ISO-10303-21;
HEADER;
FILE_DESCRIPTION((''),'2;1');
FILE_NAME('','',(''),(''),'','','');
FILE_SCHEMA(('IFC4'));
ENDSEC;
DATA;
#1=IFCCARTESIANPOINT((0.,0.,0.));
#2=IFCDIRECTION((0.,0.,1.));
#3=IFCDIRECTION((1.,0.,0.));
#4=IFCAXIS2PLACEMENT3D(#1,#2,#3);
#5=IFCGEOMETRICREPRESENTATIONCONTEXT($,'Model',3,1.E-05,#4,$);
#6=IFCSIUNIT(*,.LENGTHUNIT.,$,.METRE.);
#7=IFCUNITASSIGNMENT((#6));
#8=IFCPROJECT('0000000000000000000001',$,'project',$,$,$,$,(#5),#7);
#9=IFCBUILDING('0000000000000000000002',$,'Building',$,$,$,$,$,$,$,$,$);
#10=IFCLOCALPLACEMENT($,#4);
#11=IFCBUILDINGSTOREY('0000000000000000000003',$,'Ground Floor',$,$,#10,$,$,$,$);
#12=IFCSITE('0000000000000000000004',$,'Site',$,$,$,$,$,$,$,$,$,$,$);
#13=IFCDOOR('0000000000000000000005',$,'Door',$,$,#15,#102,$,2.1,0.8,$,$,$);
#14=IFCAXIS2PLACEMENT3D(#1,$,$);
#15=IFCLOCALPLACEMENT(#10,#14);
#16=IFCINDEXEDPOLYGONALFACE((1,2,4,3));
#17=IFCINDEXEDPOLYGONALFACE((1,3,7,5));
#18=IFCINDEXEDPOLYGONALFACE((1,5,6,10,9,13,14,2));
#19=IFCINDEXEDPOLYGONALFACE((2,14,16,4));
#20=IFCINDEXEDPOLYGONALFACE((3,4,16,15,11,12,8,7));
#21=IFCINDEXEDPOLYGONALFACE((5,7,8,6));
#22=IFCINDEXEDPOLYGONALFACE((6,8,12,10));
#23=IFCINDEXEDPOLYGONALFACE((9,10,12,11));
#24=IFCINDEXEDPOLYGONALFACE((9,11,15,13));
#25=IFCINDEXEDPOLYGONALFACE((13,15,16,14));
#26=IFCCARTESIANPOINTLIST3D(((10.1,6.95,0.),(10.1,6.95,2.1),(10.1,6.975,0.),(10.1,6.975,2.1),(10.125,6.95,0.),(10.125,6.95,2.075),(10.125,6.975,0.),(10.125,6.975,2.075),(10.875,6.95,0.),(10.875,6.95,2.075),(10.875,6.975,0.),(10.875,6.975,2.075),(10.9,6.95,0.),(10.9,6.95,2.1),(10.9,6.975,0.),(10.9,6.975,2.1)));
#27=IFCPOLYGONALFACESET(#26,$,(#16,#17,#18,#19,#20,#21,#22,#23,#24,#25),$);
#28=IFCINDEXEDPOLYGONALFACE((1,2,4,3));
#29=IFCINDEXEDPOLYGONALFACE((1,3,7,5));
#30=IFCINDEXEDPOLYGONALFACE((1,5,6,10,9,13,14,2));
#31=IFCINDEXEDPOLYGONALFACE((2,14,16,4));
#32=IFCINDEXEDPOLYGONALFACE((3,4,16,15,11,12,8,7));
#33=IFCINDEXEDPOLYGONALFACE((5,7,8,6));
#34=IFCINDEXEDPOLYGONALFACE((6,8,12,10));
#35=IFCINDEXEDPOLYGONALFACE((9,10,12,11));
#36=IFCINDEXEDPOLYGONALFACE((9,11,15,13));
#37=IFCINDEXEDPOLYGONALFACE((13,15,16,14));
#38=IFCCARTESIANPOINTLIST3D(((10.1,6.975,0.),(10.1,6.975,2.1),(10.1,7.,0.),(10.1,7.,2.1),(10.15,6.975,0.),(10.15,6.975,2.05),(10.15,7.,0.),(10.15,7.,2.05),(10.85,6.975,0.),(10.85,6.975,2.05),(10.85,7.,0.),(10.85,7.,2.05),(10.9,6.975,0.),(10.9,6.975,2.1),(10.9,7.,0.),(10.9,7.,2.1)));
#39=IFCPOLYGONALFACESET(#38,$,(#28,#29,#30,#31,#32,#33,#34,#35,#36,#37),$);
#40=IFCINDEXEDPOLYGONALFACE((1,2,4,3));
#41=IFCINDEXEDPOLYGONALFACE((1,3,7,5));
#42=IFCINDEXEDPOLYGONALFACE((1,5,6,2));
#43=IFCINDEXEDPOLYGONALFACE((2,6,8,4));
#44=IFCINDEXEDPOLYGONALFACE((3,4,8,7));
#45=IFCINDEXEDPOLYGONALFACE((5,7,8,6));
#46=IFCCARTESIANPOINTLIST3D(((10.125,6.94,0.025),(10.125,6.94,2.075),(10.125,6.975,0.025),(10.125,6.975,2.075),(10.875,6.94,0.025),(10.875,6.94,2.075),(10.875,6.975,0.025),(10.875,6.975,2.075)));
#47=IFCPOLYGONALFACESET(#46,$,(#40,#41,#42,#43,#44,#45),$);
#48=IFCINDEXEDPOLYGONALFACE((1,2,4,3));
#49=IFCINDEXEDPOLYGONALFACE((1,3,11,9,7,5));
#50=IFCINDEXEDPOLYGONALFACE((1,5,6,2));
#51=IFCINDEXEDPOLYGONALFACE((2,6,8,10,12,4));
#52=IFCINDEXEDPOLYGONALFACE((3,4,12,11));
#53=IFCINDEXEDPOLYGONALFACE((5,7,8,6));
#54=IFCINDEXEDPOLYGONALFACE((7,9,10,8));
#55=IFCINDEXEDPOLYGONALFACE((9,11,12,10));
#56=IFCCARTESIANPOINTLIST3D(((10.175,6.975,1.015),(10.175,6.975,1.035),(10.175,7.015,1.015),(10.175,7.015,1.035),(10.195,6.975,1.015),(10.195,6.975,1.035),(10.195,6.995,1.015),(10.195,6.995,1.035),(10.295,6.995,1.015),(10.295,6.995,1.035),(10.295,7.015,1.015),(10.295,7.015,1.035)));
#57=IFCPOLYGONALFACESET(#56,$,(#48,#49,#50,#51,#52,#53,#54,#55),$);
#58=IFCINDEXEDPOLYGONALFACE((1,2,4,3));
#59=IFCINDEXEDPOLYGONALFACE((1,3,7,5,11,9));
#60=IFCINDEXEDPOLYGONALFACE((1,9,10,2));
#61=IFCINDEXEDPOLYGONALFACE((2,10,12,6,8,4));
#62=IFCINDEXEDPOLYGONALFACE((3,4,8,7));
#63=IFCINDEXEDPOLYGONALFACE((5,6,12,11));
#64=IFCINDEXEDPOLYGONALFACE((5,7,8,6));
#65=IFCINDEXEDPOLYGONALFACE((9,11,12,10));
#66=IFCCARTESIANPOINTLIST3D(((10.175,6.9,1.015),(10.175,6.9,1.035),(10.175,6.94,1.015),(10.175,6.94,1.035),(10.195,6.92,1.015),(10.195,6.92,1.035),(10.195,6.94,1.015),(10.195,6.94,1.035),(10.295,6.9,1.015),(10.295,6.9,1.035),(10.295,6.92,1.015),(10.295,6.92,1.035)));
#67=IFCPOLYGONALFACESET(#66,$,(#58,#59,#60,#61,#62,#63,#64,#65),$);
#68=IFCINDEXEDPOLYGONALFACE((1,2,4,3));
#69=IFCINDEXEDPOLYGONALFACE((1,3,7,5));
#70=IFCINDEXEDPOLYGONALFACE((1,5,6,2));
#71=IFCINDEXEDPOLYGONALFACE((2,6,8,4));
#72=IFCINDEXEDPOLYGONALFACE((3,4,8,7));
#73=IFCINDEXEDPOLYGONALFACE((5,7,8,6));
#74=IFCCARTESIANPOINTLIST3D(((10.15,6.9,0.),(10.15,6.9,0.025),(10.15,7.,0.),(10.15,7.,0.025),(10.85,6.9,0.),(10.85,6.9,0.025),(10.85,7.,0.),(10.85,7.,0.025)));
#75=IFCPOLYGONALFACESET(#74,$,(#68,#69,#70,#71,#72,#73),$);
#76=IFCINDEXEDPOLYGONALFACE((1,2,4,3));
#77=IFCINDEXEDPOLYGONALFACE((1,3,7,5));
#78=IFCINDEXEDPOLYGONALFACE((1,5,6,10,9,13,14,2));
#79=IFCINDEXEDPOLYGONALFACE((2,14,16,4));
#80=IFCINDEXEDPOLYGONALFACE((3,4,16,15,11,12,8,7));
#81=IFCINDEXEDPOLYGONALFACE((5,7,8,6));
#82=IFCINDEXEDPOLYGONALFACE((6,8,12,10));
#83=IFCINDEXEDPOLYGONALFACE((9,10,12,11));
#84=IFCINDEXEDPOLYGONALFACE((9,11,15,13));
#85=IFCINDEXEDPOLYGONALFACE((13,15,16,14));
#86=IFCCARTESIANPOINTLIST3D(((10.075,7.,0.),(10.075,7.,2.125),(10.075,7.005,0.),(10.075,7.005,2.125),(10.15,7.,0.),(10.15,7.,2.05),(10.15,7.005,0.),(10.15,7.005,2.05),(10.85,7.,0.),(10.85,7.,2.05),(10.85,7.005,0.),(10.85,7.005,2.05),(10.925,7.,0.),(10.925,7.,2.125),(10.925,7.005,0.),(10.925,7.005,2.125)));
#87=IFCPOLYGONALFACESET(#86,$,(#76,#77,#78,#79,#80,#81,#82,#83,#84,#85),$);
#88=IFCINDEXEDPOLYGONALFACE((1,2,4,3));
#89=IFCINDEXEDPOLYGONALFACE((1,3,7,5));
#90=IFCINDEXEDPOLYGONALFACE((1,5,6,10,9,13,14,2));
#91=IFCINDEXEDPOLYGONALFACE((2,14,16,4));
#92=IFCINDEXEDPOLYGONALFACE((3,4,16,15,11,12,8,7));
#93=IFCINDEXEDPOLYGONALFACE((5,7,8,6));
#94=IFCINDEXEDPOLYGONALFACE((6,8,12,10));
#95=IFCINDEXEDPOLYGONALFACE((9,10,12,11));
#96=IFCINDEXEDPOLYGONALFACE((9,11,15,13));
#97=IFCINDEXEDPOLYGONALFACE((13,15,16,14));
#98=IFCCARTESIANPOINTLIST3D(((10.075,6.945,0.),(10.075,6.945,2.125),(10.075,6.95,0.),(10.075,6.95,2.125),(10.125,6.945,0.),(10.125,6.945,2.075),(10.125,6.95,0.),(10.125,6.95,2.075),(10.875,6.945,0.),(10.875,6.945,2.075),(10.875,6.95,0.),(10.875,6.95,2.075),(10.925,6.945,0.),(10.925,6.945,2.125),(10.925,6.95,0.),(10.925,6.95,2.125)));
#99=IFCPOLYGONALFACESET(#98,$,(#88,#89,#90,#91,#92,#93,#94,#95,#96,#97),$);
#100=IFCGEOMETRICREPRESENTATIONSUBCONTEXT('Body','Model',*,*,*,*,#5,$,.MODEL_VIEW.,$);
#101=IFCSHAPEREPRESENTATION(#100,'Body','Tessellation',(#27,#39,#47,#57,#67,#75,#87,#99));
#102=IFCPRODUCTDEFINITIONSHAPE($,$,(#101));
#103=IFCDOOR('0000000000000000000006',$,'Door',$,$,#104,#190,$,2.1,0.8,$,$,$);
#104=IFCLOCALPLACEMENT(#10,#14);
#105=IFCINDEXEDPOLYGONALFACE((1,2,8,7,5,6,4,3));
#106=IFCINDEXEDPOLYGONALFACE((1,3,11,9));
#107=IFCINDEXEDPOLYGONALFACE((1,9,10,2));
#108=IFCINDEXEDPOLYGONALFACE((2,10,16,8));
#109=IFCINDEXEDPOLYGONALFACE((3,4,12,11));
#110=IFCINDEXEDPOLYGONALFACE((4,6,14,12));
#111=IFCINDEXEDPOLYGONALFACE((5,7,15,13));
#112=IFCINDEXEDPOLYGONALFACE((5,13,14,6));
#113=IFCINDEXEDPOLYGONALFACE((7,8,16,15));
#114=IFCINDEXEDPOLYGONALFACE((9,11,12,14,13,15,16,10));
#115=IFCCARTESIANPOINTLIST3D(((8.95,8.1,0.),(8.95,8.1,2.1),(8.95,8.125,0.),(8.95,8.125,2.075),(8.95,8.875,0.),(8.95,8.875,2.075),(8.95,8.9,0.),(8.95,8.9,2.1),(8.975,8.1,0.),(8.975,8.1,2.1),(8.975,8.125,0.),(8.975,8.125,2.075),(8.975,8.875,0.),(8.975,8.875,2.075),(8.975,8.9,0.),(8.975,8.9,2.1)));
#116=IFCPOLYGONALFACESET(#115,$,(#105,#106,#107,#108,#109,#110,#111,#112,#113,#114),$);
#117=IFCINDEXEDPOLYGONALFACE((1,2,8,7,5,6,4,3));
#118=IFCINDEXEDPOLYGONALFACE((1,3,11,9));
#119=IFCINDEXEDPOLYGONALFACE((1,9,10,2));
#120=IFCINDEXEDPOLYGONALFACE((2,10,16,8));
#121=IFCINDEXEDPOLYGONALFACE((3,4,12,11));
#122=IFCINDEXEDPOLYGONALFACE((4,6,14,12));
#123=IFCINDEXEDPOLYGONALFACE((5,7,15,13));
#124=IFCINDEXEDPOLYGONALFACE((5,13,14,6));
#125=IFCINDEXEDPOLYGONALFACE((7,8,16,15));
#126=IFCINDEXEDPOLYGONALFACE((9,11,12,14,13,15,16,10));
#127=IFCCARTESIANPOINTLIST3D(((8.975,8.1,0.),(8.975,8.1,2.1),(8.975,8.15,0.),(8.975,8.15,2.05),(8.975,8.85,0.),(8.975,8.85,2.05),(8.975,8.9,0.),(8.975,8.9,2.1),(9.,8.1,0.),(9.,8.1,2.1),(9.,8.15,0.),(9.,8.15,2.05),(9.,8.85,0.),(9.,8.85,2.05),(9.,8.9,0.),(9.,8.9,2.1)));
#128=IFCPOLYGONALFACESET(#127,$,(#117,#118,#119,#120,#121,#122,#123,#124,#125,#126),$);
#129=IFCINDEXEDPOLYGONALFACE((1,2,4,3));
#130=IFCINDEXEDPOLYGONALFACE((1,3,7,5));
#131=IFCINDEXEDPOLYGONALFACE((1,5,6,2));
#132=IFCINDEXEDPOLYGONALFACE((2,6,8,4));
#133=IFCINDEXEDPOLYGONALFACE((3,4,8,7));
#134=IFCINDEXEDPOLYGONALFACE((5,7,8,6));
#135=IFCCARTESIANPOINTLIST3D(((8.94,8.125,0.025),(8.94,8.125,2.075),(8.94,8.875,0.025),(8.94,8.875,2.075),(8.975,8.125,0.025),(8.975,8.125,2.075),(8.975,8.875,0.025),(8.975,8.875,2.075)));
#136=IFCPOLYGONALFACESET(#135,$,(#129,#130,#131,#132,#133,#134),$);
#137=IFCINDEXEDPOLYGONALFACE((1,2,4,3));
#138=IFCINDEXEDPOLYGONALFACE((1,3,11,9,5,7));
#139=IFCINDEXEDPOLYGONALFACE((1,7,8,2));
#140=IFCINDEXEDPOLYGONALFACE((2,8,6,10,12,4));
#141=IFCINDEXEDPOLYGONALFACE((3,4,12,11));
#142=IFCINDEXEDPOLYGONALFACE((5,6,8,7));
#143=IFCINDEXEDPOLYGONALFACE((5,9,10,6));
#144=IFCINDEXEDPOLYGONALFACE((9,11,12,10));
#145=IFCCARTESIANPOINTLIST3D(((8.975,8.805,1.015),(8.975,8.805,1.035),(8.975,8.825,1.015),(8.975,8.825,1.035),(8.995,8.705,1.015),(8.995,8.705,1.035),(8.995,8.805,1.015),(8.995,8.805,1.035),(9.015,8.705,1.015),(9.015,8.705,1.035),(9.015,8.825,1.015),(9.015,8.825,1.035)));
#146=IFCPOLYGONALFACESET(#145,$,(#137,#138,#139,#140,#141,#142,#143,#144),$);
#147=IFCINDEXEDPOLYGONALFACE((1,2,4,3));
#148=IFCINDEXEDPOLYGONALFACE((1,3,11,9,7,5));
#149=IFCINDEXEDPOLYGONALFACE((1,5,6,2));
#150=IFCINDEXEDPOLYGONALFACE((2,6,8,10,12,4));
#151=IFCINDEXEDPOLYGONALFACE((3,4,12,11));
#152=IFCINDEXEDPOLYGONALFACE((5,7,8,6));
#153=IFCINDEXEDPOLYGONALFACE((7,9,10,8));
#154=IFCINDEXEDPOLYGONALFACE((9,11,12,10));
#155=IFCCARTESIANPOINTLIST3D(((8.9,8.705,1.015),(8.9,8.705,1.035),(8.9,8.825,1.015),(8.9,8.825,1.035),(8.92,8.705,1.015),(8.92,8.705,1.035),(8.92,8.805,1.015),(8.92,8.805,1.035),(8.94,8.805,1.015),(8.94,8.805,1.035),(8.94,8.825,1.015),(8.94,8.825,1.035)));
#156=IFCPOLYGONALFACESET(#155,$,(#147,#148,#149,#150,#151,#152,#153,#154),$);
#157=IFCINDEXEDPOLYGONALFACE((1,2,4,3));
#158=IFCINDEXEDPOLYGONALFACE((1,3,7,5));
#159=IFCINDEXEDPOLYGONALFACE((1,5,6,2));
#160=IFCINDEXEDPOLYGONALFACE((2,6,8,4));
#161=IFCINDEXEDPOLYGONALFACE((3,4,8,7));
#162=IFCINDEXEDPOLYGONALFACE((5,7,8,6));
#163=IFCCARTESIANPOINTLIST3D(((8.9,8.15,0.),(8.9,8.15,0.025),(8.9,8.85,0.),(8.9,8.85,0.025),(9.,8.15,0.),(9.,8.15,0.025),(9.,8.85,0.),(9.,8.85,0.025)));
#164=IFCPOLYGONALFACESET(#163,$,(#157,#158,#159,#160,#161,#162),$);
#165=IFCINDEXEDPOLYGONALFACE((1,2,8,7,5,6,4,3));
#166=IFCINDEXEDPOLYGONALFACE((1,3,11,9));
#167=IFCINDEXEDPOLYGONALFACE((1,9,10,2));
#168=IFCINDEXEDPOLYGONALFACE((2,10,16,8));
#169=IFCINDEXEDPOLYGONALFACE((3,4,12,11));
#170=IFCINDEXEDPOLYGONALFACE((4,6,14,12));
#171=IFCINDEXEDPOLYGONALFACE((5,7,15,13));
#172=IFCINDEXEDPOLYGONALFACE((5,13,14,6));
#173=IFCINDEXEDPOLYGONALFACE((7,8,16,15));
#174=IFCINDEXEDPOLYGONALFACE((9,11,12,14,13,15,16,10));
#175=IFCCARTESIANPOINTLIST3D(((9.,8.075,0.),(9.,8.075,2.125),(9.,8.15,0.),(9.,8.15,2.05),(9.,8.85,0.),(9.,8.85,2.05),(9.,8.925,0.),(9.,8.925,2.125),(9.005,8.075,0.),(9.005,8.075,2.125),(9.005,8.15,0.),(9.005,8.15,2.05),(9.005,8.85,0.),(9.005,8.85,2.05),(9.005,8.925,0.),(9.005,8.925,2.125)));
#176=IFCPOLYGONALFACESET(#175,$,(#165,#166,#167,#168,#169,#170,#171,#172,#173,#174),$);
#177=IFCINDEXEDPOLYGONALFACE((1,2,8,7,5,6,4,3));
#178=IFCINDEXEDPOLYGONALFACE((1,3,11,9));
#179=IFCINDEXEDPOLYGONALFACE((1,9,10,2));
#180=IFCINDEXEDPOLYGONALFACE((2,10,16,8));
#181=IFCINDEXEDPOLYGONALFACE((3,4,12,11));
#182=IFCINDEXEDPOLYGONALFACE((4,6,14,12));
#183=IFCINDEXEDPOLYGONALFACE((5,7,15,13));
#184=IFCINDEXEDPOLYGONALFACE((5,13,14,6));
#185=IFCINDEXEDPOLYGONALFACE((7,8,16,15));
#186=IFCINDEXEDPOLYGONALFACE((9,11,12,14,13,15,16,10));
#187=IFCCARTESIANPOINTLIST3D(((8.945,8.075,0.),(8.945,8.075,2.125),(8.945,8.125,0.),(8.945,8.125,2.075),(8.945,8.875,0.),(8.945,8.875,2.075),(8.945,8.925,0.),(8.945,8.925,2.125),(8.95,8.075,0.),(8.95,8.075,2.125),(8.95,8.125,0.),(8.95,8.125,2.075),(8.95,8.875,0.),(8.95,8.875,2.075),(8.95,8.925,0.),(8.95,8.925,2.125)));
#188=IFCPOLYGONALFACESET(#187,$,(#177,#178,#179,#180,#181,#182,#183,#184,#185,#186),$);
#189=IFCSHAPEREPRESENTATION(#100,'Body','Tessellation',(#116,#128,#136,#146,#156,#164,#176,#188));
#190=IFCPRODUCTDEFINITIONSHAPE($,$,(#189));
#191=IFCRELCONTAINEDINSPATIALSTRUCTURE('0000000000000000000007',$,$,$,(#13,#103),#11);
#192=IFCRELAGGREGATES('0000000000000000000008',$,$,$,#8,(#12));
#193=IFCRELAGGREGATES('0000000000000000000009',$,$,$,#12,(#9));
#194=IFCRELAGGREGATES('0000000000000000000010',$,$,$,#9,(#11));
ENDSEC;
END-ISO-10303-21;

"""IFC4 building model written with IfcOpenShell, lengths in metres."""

from ifc_helpers import new_model, si_unit, frame, origin_with_axes, place, context, subcontext, project, spatial, line, indexed_curve, outline, extrude, element, save


model = new_model("IFC4")

# Units and contexts
model_context = context("Model", 3, precision=1e-05, world=origin_with_axes())
body_context = subcontext(model_context, "Body", "Model", "MODEL_VIEW")
ifc_project = project(units=[si_unit("LENGTHUNIT", "METRE")], contexts=[model_context])

# Site, building, storey
site = spatial("IfcSite", under=ifc_project, Name="Site")
building = spatial("IfcBuilding", under=site, Name="Building")
storey_placement = place(None, origin_with_axes())
storey = spatial("IfcBuildingStorey", under=building, at=storey_placement, Name="Ground Floor")

# Doors
door_1_placement = place(storey_placement, frame((10.9, 7.0, 0.0), z_axis=(0.0, 0.0, 1.0), x_axis=(-1.0, 0.0, 0.0)))
element("IfcDoor", 1, at=door_1_placement, inside=storey, Name="Door", OverallHeight=2.1, OverallWidth=0.8, context=body_context, shape_type="SweptSolid", body=[
    extrude(outline(indexed_curve([(0.0, 0.0), (0.0, 2.1), (0.8, 2.1), (0.8, 0.0), (0.775, 0.0), (0.775, 2.075), (0.025, 2.075), (0.025, 0.0)], segments=[line(1, 2, 3, 4, 5, 6, 7, 8, 1)])), frame((0.0, 0.025, 0.0), z_axis=(0.0, -1.0, 0.0), x_axis=(1.0, 0.0, 0.0)), (0.0, 0.0, -1.0), 0.025),
    extrude(outline(indexed_curve([(0.0, 0.0), (0.0, 2.1), (0.8, 2.1), (0.8, 0.0), (0.75, 0.0), (0.75, 2.05), (0.05, 2.05), (0.05, 0.0)], segments=[line(1, 2, 3, 4, 5, 6, 7, 8, 1)])), frame((0.0, 0.0, 0.0), z_axis=(0.0, -1.0, 0.0), x_axis=(1.0, 0.0, 0.0)), (0.0, 0.0, -1.0), 0.025),
    extrude(outline(indexed_curve([(0.0, 0.0), (0.75, 0.0), (0.75, 0.035), (0.0, 0.035)], segments=[line(1, 2, 3, 4, 1)])), frame((0.025, 0.025, 0.025), z_axis=(0.0, 0.0, 1.0), x_axis=(1.0, 0.0, 0.0)), (0.0, 0.0, 1.0), 2.05),
    extrude(outline(indexed_curve([(0.0, 0.0), (0.0, -0.04), (-0.12, -0.04), (-0.12, -0.02), (-0.02, -0.02), (-0.02, 0.0)], segments=[line(1, 2, 3, 4, 5, 6, 1)])), frame((0.725, 0.025, 1.015), z_axis=(0.0, 0.0, 1.0), x_axis=(1.0, 0.0, 0.0)), (0.0, 0.0, 1.0), 0.02),
    extrude(outline(indexed_curve([(0.0, 0.0), (0.0, 0.04), (-0.12, 0.04), (-0.12, 0.02), (-0.02, 0.02), (-0.02, 0.0)], segments=[line(1, 2, 3, 4, 5, 6, 1)])), frame((0.725, 0.06, 1.015), z_axis=(0.0, 0.0, 1.0), x_axis=(1.0, 0.0, 0.0)), (0.0, 0.0, 1.0), 0.02),
    extrude(outline(indexed_curve([(0.0, 0.0), (0.7, 0.0), (0.7, 0.1), (0.0, 0.1)], segments=[line(1, 2, 3, 4, 1)])), frame((0.05, 0.0, 0.0), z_axis=(0.0, 0.0, 1.0), x_axis=(1.0, 0.0, 0.0)), (0.0, 0.0, 1.0), 0.025),
    extrude(outline(indexed_curve([(0.0, 0.0), (0.0, 2.125), (0.85, 2.125), (0.85, 0.0), (0.775, 0.0), (0.775, 2.05), (0.075, 2.05), (0.075, 0.0)], segments=[line(1, 2, 3, 4, 5, 6, 7, 8, 1)])), frame((-0.025, -0.005, 0.0), z_axis=(0.0, -1.0, 0.0), x_axis=(1.0, 0.0, 0.0)), (0.0, 0.0, -1.0), 0.005),
    extrude(outline(indexed_curve([(0.0, 0.0), (0.0, 2.125), (0.85, 2.125), (0.85, 0.0), (0.8, 0.0), (0.8, 2.075), (0.05, 2.075), (0.05, 0.0)], segments=[line(1, 2, 3, 4, 5, 6, 7, 8, 1)])), frame((-0.025, 0.05, 0.0), z_axis=(0.0, -1.0, 0.0), x_axis=(1.0, 0.0, 0.0)), (0.0, 0.0, -1.0), 0.005),
])
door_2_placement = place(storey_placement, frame((9.0, 8.1, 0.0), z_axis=(0.0, 0.0, 1.0), x_axis=(0.0, 1.0, 0.0)))
element("IfcDoor", 2, at=door_2_placement, inside=storey, Name="Door", OverallHeight=2.1, OverallWidth=0.8, context=body_context, shape_type="SweptSolid", body=[
    extrude(outline(indexed_curve([(0.0, 0.0), (0.0, 2.1), (0.8, 2.1), (0.8, 0.0), (0.775, 0.0), (0.775, 2.075), (0.025, 2.075), (0.025, 0.0)], segments=[line(1, 2, 3, 4, 5, 6, 7, 8, 1)])), frame((0.0, 0.025, 0.0), z_axis=(0.0, -1.0, 0.0), x_axis=(1.0, 0.0, 0.0)), (0.0, 0.0, -1.0), 0.025),
    extrude(outline(indexed_curve([(0.0, 0.0), (0.0, 2.1), (0.8, 2.1), (0.8, 0.0), (0.75, 0.0), (0.75, 2.05), (0.05, 2.05), (0.05, 0.0)], segments=[line(1, 2, 3, 4, 5, 6, 7, 8, 1)])), frame((0.0, 0.0, 0.0), z_axis=(0.0, -1.0, 0.0), x_axis=(1.0, 0.0, 0.0)), (0.0, 0.0, -1.0), 0.025),
    extrude(outline(indexed_curve([(0.0, 0.0), (0.75, 0.0), (0.75, 0.035), (0.0, 0.035)], segments=[line(1, 2, 3, 4, 1)])), frame((0.025, 0.025, 0.025), z_axis=(0.0, 0.0, 1.0), x_axis=(1.0, 0.0, 0.0)), (0.0, 0.0, 1.0), 2.05),
    extrude(outline(indexed_curve([(0.0, 0.0), (0.0, -0.04), (-0.12, -0.04), (-0.12, -0.02), (-0.02, -0.02), (-0.02, 0.0)], segments=[line(1, 2, 3, 4, 5, 6, 1)])), frame((0.725, 0.025, 1.015), z_axis=(0.0, 0.0, 1.0), x_axis=(1.0, 0.0, 0.0)), (0.0, 0.0, 1.0), 0.02),
    extrude(outline(indexed_curve([(0.0, 0.0), (0.0, 0.04), (-0.12, 0.04), (-0.12, 0.02), (-0.02, 0.02), (-0.02, 0.0)], segments=[line(1, 2, 3, 4, 5, 6, 1)])), frame((0.725, 0.06, 1.015), z_axis=(0.0, 0.0, 1.0), x_axis=(1.0, 0.0, 0.0)), (0.0, 0.0, 1.0), 0.02),
    extrude(outline(indexed_curve([(0.0, 0.0), (0.7, 0.0), (0.7, 0.1), (0.0, 0.1)], segments=[line(1, 2, 3, 4, 1)])), frame((0.05, 0.0, 0.0), z_axis=(0.0, 0.0, 1.0), x_axis=(1.0, 0.0, 0.0)), (0.0, 0.0, 1.0), 0.025),
    extrude(outline(indexed_curve([(0.0, 0.0), (0.0, 2.125), (0.85, 2.125), (0.85, 0.0), (0.775, 0.0), (0.775, 2.05), (0.075, 2.05), (0.075, 0.0)], segments=[line(1, 2, 3, 4, 5, 6, 7, 8, 1)])), frame((-0.025, -0.005, 0.0), z_axis=(0.0, -1.0, 0.0), x_axis=(1.0, 0.0, 0.0)), (0.0, 0.0, -1.0), 0.005),
    extrude(outline(indexed_curve([(0.0, 0.0), (0.0, 2.125), (0.85, 2.125), (0.85, 0.0), (0.8, 0.0), (0.8, 2.075), (0.05, 2.075), (0.05, 0.0)], segments=[line(1, 2, 3, 4, 5, 6, 7, 8, 1)])), frame((-0.025, 0.05, 0.0), z_axis=(0.0, -1.0, 0.0), x_axis=(1.0, 0.0, 0.0)), (0.0, 0.0, -1.0), 0.005),
])

save(model, "model.ifc")
